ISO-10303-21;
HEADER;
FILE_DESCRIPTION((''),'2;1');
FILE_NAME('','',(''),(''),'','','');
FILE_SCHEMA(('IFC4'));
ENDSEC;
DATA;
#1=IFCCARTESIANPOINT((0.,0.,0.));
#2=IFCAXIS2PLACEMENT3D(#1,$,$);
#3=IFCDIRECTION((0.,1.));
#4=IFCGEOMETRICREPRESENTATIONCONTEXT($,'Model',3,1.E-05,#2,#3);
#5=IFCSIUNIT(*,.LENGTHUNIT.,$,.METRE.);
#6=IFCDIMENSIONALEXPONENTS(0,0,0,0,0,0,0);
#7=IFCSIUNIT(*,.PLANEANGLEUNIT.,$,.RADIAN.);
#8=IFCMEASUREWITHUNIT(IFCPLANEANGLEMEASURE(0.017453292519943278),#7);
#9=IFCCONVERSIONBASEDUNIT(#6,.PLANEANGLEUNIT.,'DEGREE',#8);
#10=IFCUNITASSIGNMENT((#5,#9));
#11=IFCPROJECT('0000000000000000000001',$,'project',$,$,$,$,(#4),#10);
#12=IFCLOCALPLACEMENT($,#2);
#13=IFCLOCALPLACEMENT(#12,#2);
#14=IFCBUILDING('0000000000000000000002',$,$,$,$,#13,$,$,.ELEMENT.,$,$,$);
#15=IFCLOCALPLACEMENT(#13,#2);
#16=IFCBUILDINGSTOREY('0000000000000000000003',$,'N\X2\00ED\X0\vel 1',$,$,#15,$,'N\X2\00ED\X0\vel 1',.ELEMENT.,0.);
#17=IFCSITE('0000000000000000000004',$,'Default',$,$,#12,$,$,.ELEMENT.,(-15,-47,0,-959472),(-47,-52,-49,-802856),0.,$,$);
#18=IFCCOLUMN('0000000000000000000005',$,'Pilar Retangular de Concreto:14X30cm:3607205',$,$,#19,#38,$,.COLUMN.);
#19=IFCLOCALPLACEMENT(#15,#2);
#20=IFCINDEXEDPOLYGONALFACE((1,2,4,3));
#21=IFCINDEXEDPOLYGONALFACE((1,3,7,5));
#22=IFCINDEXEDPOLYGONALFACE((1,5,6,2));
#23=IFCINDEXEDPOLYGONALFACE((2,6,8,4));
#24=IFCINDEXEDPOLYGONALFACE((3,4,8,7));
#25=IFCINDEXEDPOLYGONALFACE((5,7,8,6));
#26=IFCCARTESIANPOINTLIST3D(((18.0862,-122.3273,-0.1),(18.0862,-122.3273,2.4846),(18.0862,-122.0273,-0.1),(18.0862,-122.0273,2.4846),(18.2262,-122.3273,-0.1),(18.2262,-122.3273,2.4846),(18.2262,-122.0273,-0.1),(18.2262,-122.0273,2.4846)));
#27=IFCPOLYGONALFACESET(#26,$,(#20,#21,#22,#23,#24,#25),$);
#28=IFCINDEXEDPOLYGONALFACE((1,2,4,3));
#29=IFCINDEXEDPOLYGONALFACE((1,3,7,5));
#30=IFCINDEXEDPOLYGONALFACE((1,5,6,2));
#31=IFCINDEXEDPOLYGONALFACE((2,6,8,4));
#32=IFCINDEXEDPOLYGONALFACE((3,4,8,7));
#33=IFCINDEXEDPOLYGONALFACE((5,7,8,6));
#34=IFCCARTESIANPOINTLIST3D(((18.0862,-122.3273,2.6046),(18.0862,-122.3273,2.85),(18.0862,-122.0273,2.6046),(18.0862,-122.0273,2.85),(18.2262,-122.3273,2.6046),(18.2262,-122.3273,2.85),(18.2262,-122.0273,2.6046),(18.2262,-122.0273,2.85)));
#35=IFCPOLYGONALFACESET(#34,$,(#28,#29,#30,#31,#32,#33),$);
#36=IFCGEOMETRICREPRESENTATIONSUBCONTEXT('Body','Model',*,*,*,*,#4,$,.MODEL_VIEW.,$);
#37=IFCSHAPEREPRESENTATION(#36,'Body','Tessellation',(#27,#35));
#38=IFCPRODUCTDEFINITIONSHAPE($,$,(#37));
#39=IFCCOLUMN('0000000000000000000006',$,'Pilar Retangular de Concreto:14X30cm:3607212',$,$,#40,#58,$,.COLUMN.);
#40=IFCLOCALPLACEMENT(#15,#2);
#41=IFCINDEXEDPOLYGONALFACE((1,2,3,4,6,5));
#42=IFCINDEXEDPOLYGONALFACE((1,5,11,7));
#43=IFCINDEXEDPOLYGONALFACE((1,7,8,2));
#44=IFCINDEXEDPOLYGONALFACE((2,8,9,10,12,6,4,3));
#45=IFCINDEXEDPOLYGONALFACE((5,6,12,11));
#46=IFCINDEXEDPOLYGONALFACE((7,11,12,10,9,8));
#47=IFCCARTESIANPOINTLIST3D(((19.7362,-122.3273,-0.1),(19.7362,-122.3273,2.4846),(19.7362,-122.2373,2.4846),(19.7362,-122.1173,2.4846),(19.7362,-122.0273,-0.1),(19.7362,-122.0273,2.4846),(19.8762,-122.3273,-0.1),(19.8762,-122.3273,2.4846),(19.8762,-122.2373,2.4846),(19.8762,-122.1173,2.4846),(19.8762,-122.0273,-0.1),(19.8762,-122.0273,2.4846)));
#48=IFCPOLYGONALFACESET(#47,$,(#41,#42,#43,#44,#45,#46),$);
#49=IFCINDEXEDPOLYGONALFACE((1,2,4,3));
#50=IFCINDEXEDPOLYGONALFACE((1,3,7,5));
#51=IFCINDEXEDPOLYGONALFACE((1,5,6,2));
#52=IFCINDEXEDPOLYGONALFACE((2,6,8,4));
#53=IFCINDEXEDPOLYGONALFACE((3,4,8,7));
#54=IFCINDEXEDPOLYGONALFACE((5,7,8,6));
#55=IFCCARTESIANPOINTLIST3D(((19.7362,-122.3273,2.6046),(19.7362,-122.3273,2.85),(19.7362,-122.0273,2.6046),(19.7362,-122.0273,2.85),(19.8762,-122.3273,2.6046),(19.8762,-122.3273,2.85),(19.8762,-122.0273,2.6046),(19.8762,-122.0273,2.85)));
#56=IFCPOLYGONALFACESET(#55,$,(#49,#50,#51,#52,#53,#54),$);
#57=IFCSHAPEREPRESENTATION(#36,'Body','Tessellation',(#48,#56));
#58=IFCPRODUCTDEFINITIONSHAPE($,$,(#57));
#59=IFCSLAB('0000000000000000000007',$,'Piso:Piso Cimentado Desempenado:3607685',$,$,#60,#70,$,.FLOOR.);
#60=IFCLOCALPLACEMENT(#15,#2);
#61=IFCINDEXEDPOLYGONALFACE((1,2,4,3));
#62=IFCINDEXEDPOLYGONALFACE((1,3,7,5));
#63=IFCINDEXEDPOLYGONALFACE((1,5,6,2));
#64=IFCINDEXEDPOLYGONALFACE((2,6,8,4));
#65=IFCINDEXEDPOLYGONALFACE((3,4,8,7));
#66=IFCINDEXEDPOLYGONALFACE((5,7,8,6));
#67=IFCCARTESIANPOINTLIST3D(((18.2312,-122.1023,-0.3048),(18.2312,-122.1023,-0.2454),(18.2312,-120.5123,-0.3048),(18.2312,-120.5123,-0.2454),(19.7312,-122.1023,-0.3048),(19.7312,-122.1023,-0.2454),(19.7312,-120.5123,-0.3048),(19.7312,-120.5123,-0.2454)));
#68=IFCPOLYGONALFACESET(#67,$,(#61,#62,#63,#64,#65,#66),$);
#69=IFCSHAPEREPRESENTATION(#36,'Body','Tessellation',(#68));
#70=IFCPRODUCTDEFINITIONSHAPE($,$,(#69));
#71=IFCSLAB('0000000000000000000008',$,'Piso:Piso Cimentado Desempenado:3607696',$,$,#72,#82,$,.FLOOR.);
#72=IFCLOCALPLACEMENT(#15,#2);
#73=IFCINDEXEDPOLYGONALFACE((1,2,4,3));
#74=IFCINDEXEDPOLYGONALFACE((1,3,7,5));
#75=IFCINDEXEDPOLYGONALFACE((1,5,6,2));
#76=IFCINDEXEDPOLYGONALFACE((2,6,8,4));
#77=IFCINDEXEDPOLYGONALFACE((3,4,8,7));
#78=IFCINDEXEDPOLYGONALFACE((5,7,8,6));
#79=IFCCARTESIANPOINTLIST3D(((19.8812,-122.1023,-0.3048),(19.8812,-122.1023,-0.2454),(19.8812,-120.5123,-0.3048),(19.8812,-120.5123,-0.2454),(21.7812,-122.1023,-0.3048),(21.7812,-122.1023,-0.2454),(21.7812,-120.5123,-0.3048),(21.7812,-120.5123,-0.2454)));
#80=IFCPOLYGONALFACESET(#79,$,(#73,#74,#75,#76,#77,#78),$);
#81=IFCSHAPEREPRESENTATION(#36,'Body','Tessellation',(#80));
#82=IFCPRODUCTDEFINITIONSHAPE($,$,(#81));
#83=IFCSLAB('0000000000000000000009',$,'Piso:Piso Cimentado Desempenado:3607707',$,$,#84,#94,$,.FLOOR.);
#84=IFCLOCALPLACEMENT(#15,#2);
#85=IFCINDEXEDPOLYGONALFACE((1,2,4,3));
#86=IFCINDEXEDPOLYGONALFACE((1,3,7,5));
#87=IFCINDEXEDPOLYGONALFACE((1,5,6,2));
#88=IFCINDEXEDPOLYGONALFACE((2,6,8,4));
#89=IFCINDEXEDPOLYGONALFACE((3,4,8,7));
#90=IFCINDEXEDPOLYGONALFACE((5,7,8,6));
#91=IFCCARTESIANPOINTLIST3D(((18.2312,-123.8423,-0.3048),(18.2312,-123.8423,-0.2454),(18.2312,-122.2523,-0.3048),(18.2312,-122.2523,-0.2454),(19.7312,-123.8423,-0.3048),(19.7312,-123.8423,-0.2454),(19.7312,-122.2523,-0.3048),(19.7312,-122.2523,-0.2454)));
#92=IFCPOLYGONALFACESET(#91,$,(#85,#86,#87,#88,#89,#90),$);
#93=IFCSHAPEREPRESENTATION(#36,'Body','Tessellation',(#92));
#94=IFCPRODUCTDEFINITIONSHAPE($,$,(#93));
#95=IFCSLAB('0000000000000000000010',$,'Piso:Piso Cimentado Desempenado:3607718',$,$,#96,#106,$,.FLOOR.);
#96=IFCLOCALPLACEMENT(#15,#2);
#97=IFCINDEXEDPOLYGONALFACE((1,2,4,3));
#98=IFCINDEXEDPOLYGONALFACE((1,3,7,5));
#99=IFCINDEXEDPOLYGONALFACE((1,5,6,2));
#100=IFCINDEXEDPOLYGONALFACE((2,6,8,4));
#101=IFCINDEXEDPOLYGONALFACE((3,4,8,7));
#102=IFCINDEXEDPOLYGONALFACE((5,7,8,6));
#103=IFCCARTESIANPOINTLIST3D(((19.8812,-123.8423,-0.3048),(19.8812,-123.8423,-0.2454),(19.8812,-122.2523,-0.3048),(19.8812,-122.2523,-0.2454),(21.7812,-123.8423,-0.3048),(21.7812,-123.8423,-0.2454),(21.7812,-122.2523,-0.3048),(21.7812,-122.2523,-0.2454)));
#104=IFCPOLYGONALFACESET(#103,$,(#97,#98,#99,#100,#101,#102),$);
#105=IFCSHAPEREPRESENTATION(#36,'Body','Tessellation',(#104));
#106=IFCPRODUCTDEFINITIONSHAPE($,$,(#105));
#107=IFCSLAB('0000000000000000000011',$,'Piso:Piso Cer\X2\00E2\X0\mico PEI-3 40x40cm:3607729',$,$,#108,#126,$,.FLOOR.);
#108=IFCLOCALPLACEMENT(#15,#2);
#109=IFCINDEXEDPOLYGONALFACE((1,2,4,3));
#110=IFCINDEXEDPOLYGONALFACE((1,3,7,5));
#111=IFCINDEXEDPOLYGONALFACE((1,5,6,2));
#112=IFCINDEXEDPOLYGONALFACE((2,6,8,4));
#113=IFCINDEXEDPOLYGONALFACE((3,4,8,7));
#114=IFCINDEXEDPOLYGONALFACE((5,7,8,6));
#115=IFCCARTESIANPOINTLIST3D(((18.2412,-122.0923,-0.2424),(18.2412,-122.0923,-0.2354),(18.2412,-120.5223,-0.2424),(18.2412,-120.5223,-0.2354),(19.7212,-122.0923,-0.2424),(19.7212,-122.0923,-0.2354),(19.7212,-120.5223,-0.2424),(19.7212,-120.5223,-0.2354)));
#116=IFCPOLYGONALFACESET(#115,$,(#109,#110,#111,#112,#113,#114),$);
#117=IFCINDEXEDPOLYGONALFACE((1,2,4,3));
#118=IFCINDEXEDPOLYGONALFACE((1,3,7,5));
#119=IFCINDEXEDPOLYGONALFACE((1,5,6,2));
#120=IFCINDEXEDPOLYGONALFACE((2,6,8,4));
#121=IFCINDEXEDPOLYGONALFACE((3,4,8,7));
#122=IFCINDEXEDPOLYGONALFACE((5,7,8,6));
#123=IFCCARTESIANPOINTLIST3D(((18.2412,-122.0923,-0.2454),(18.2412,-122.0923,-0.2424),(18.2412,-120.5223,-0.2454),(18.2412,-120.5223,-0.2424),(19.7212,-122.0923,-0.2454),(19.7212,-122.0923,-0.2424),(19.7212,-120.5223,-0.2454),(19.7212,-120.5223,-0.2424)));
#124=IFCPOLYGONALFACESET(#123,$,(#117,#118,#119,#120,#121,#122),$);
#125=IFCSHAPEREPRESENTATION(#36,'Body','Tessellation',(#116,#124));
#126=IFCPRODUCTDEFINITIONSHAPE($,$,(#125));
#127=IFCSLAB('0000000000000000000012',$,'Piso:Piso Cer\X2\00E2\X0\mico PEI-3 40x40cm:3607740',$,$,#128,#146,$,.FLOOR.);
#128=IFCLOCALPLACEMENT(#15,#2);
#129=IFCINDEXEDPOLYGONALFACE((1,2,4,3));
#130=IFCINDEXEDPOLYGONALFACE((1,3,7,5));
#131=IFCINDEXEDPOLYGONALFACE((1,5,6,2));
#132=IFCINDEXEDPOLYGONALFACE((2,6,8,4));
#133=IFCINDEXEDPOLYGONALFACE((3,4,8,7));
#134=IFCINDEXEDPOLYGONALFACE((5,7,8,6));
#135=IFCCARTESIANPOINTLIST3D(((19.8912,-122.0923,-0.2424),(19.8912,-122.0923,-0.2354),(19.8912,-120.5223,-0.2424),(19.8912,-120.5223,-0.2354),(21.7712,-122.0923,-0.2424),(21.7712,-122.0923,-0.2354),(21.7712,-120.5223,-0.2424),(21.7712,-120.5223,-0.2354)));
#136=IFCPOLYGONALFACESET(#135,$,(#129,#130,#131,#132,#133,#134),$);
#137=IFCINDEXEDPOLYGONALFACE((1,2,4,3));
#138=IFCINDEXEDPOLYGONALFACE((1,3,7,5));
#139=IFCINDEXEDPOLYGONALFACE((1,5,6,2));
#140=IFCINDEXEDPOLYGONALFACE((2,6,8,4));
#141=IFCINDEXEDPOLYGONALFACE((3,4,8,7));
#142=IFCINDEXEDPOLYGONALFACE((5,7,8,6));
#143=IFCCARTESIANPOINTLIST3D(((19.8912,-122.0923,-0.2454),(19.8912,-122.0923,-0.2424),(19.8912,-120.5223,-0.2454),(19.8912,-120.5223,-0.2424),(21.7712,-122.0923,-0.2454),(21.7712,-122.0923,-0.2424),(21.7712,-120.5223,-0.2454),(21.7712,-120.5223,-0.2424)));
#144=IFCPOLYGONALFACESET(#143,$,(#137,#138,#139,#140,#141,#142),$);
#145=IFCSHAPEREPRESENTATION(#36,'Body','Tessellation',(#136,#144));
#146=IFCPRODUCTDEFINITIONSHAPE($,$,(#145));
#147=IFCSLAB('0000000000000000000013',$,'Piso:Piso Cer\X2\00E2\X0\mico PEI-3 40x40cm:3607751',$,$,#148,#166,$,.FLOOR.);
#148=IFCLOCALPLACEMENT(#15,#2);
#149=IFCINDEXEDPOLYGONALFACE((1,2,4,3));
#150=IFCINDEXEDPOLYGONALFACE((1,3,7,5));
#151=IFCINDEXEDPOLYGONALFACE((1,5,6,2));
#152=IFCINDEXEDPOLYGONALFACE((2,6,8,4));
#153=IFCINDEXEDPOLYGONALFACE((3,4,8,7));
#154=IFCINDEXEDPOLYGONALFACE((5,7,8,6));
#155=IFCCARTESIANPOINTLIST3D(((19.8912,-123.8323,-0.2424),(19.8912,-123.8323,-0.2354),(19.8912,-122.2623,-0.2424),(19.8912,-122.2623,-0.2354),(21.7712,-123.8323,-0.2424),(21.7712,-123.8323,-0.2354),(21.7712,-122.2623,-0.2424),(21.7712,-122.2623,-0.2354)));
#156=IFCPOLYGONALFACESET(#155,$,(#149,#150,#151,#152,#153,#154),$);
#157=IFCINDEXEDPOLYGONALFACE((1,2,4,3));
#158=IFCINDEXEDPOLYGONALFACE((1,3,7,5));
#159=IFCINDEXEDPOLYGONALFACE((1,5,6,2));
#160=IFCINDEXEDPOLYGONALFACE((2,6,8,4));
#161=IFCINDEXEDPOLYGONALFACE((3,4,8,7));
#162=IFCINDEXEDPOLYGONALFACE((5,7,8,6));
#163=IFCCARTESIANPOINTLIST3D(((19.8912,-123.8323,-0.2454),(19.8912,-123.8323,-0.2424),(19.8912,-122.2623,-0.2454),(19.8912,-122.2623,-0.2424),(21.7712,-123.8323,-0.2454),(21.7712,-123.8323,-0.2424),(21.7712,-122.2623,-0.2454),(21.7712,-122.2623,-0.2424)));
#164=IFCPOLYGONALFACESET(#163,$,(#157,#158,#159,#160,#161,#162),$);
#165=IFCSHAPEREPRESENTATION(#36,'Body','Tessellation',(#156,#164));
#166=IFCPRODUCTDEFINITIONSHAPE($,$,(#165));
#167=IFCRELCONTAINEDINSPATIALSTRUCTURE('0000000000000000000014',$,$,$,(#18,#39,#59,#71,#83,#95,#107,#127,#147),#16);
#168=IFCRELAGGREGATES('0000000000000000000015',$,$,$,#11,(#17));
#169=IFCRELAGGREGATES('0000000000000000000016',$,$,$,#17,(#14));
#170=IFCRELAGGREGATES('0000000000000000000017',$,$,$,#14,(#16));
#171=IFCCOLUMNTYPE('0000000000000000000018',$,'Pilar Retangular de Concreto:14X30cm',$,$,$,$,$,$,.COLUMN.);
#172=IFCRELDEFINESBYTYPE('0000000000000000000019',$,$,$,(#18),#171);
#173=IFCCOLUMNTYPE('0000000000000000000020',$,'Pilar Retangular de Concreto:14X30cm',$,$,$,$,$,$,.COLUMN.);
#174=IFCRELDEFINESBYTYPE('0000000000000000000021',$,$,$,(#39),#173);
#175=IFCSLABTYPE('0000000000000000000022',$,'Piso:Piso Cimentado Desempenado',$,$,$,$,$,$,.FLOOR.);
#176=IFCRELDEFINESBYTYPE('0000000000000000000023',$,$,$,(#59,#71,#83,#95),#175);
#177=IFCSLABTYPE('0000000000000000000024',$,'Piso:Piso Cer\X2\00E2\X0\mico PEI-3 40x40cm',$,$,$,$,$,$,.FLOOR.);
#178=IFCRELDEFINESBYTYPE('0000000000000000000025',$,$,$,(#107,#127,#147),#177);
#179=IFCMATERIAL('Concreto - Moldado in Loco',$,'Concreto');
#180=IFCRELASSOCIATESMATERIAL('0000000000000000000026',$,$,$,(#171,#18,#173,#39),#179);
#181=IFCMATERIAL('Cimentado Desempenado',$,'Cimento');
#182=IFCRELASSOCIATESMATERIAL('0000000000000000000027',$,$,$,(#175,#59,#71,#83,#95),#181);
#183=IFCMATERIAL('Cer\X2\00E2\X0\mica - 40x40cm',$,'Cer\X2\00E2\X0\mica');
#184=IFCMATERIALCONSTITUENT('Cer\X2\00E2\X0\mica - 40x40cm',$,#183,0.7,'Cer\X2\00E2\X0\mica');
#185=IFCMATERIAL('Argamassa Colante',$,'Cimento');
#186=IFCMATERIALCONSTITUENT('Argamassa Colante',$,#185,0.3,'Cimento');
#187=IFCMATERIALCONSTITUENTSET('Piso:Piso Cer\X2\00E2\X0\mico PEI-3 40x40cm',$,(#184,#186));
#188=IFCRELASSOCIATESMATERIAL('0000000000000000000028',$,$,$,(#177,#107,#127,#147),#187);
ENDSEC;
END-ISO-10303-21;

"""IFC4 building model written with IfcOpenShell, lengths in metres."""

from ifc_helpers import new_model, entity, si_unit, converted_unit, direction, frame, origin, place, context, subcontext, project, spatial, indexed_curve, outline, extrude, source, transform, mapped, material, constituent, constituent_set, type_object, type_shapes, element, save


model = new_model("IFC4")

# Units and contexts
model_context = context("Model", 3, precision=1e-05, world=origin(), true_north=direction((0.0, 1.0)))
body_context = subcontext(model_context, "Body", "Model", "MODEL_VIEW")
ifc_project = project(units=[si_unit("LENGTHUNIT", "METRE"), converted_unit("PLANEANGLEUNIT", "DEGREE", entity("IfcPlaneAngleMeasure", 0.017453292519943278), si_unit("PLANEANGLEUNIT", "RADIAN"), dimensions=[0, 0, 0, 0, 0, 0, 0])], contexts=[model_context])

# Site, building, storey
site_placement = place(None, origin())
site = spatial("IfcSite", under=ifc_project, at=site_placement, Name="Default", CompositionType="ELEMENT", RefLatitude=(-15, -47, 0, -959472), RefLongitude=(-47, -52, -49, -802856), RefElevation=0.0)
building_placement = place(site_placement, origin())
building = spatial("IfcBuilding", under=site, at=building_placement, CompositionType="ELEMENT")
storey_placement = place(building_placement, origin())
storey = spatial("IfcBuildingStorey", under=building, at=storey_placement, Name="Nível 1", LongName="Nível 1", CompositionType="ELEMENT", Elevation=0.0)

# Columns
ifc_material_1 = material(Name="Concreto - Moldado in Loco", Category="Concreto")
column_type_1 = type_object("IfcColumnType", Name="Pilar Retangular de Concreto:14X30cm", PredefinedType="COLUMN", material=ifc_material_1)
shared_shape_1 = source(origin(), body_context, "Body", "SweptSolid", [
    extrude(outline(indexed_curve([(-1.2923, -0.15), (1.2923, -0.15), (1.2923, 0.15), (-1.2923, 0.15), (-1.2923, -0.15)], self_intersect=False)), frame((18.0862, -122.1773, 1.1923), z_axis=(1.0, 0.0, 0.0), x_axis=(0.0, 0.0, 1.0)), (0.0, 0.0, 1.0), 0.14),
    extrude(outline(indexed_curve([(-0.1227, -0.15), (0.1227, -0.15), (0.1227, 0.15), (-0.1227, 0.15), (-0.1227, -0.15)], self_intersect=False)), frame((18.0862, -122.1773, 2.7273), z_axis=(1.0, 0.0, 0.0), x_axis=(0.0, 0.0, -1.0)), (0.0, 0.0, 1.0), 0.14),
])
type_shapes(column_type_1, [shared_shape_1])
column_1_placement = place(storey_placement, origin())
element("IfcColumn", 1, at=column_1_placement, inside=storey, type_object=column_type_1, material=ifc_material_1, Name="Pilar Retangular de Concreto:14X30cm:3607205", PredefinedType="COLUMN", context=body_context, shape_type="MappedRepresentation", body=[
    mapped(shared_shape_1, transform((0.0, 0.0, 0.0), scale=1.0)),
])
column_type_2 = type_object("IfcColumnType", Name="Pilar Retangular de Concreto:14X30cm", PredefinedType="COLUMN", material=ifc_material_1)
shared_shape_2 = source(origin(), body_context, "Body", "SweptSolid", [
    extrude(outline(indexed_curve([(-1.723, -0.15), (0.8615, -0.15), (0.8615, -0.06), (0.8615, 0.06), (0.8615, 0.15), (-1.723, 0.15), (-1.723, -0.15)], self_intersect=False)), frame((19.7362, -122.1773, 1.623), z_axis=(1.0, 0.0, 0.0), x_axis=(0.0, 0.0, 1.0)), (0.0, 0.0, 1.0), 0.14),
    extrude(outline(indexed_curve([(-0.1227, -0.15), (0.1227, -0.15), (0.1227, 0.15), (-0.1227, 0.15), (-0.1227, -0.15)], self_intersect=False)), frame((19.7362, -122.1773, 2.7273), z_axis=(1.0, 0.0, 0.0), x_axis=(0.0, 0.0, -1.0)), (0.0, 0.0, 1.0), 0.14),
])
type_shapes(column_type_2, [shared_shape_2])
column_2_placement = place(storey_placement, origin())
element("IfcColumn", 2, at=column_2_placement, inside=storey, type_object=column_type_2, material=ifc_material_1, Name="Pilar Retangular de Concreto:14X30cm:3607212", PredefinedType="COLUMN", context=body_context, shape_type="MappedRepresentation", body=[
    mapped(shared_shape_2, transform((0.0, 0.0, 0.0), scale=1.0)),
])

# Slabs
ifc_material_2 = material(Name="Cimentado Desempenado", Category="Cimento")
slab_type_1 = type_object("IfcSlabType", Name="Piso:Piso Cimentado Desempenado", PredefinedType="FLOOR", material=ifc_material_2)
slab_1_placement = place(storey_placement, origin())
element("IfcSlab", 3, at=slab_1_placement, inside=storey, type_object=slab_type_1, material=ifc_material_2, Name="Piso:Piso Cimentado Desempenado:3607685", PredefinedType="FLOOR", context=body_context, shape_type="SweptSolid", body=[
    extrude(outline(indexed_curve([(-0.795, -0.75), (0.795, -0.75), (0.795, 0.75), (-0.795, 0.75), (-0.795, -0.75)], self_intersect=False)), frame((18.9812, -121.3073, -0.2454), z_axis=(0.0, 0.0, -1.0), x_axis=(0.0, 1.0, 0.0)), (0.0, 0.0, 1.0), 0.0594),
])
slab_2_placement = place(storey_placement, origin())
element("IfcSlab", 4, at=slab_2_placement, inside=storey, type_object=slab_type_1, material=ifc_material_2, Name="Piso:Piso Cimentado Desempenado:3607696", PredefinedType="FLOOR", context=body_context, shape_type="SweptSolid", body=[
    extrude(outline(indexed_curve([(-0.795, -0.95), (0.795, -0.95), (0.795, 0.95), (-0.795, 0.95), (-0.795, -0.95)], self_intersect=False)), frame((20.8312, -121.3073, -0.2454), z_axis=(0.0, 0.0, -1.0), x_axis=(0.0, 1.0, 0.0)), (0.0, 0.0, 1.0), 0.0594),
])
slab_3_placement = place(storey_placement, origin())
element("IfcSlab", 5, at=slab_3_placement, inside=storey, type_object=slab_type_1, material=ifc_material_2, Name="Piso:Piso Cimentado Desempenado:3607707", PredefinedType="FLOOR", context=body_context, shape_type="SweptSolid", body=[
    extrude(outline(indexed_curve([(-0.795, -0.75), (0.795, -0.75), (0.795, 0.75), (-0.795, 0.75), (-0.795, -0.75)], self_intersect=False)), frame((18.9812, -123.0473, -0.2454), z_axis=(0.0, 0.0, -1.0), x_axis=(0.0, 1.0, 0.0)), (0.0, 0.0, 1.0), 0.0594),
])
slab_4_placement = place(storey_placement, origin())
element("IfcSlab", 6, at=slab_4_placement, inside=storey, type_object=slab_type_1, material=ifc_material_2, Name="Piso:Piso Cimentado Desempenado:3607718", PredefinedType="FLOOR", context=body_context, shape_type="SweptSolid", body=[
    extrude(outline(indexed_curve([(-0.795, -0.95), (0.795, -0.95), (0.795, 0.95), (-0.795, 0.95), (-0.795, -0.95)], self_intersect=False)), frame((20.8312, -123.0473, -0.2454), z_axis=(0.0, 0.0, -1.0), x_axis=(0.0, 1.0, 0.0)), (0.0, 0.0, 1.0), 0.0594),
])
ifc_material_3 = material(Name="Cerâmica - 40x40cm", Category="Cerâmica")
ifc_constituent_1 = constituent(ifc_material_3, Name="Cerâmica - 40x40cm", Category="Cerâmica", fraction=0.7)
ifc_material_4 = material(Name="Argamassa Colante", Category="Cimento")
ifc_constituent_2 = constituent(ifc_material_4, Name="Argamassa Colante", Category="Cimento", fraction=0.3)
ifc_constituent_set = constituent_set(constituents=[ifc_constituent_1, ifc_constituent_2], Name="Piso:Piso Cerâmico PEI-3 40x40cm")
slab_type_2 = type_object("IfcSlabType", Name="Piso:Piso Cerâmico PEI-3 40x40cm", PredefinedType="FLOOR", material=ifc_constituent_set)
slab_5_placement = place(storey_placement, origin())
element("IfcSlab", 7, at=slab_5_placement, inside=storey, type_object=slab_type_2, material=ifc_constituent_set, Name="Piso:Piso Cerâmico PEI-3 40x40cm:3607729", PredefinedType="FLOOR", context=body_context, shape_type="SweptSolid", body=[
    extrude(outline(indexed_curve([(-0.74, -0.785), (0.74, -0.785), (0.74, 0.785), (-0.74, 0.785), (-0.74, -0.785)], self_intersect=False)), frame((18.9812, -121.3073, -0.2424), z_axis=(0.0, 0.0, 1.0), x_axis=(-1.0, 0.0, 0.0)), (0.0, 0.0, 1.0), 0.007),
    extrude(outline(indexed_curve([(-0.74, -0.785), (0.74, -0.785), (0.74, 0.785), (-0.74, 0.785), (-0.74, -0.785)], self_intersect=False)), frame((18.9812, -121.3073, -0.2454), z_axis=(0.0, 0.0, 1.0), x_axis=(-1.0, 0.0, 0.0)), (0.0, 0.0, 1.0), 0.003),
])
slab_6_placement = place(storey_placement, origin())
element("IfcSlab", 8, at=slab_6_placement, inside=storey, type_object=slab_type_2, material=ifc_constituent_set, Name="Piso:Piso Cerâmico PEI-3 40x40cm:3607740", PredefinedType="FLOOR", context=body_context, shape_type="SweptSolid", body=[
    extrude(outline(indexed_curve([(-0.94, -0.785), (0.94, -0.785), (0.94, 0.785), (-0.94, 0.785), (-0.94, -0.785)], self_intersect=False)), frame((20.8312, -121.3073, -0.2424), z_axis=(0.0, 0.0, 1.0), x_axis=(-1.0, 0.0, 0.0)), (0.0, 0.0, 1.0), 0.007),
    extrude(outline(indexed_curve([(-0.94, -0.785), (0.94, -0.785), (0.94, 0.785), (-0.94, 0.785), (-0.94, -0.785)], self_intersect=False)), frame((20.8312, -121.3073, -0.2454), z_axis=(0.0, 0.0, 1.0), x_axis=(-1.0, 0.0, 0.0)), (0.0, 0.0, 1.0), 0.003),
])
slab_7_placement = place(storey_placement, origin())
element("IfcSlab", 9, at=slab_7_placement, inside=storey, type_object=slab_type_2, material=ifc_constituent_set, Name="Piso:Piso Cerâmico PEI-3 40x40cm:3607751", PredefinedType="FLOOR", context=body_context, shape_type="SweptSolid", body=[
    extrude(outline(indexed_curve([(-0.94, -0.785), (0.94, -0.785), (0.94, 0.785), (-0.94, 0.785), (-0.94, -0.785)], self_intersect=False)), frame((20.8312, -123.0473, -0.2424), z_axis=(0.0, 0.0, 1.0), x_axis=(-1.0, 0.0, 0.0)), (0.0, 0.0, 1.0), 0.007),
    extrude(outline(indexed_curve([(-0.94, -0.785), (0.94, -0.785), (0.94, 0.785), (-0.94, 0.785), (-0.94, -0.785)], self_intersect=False)), frame((20.8312, -123.0473, -0.2454), z_axis=(0.0, 0.0, 1.0), x_axis=(-1.0, 0.0, 0.0)), (0.0, 0.0, 1.0), 0.003),
])

save(model, "model.ifc")
